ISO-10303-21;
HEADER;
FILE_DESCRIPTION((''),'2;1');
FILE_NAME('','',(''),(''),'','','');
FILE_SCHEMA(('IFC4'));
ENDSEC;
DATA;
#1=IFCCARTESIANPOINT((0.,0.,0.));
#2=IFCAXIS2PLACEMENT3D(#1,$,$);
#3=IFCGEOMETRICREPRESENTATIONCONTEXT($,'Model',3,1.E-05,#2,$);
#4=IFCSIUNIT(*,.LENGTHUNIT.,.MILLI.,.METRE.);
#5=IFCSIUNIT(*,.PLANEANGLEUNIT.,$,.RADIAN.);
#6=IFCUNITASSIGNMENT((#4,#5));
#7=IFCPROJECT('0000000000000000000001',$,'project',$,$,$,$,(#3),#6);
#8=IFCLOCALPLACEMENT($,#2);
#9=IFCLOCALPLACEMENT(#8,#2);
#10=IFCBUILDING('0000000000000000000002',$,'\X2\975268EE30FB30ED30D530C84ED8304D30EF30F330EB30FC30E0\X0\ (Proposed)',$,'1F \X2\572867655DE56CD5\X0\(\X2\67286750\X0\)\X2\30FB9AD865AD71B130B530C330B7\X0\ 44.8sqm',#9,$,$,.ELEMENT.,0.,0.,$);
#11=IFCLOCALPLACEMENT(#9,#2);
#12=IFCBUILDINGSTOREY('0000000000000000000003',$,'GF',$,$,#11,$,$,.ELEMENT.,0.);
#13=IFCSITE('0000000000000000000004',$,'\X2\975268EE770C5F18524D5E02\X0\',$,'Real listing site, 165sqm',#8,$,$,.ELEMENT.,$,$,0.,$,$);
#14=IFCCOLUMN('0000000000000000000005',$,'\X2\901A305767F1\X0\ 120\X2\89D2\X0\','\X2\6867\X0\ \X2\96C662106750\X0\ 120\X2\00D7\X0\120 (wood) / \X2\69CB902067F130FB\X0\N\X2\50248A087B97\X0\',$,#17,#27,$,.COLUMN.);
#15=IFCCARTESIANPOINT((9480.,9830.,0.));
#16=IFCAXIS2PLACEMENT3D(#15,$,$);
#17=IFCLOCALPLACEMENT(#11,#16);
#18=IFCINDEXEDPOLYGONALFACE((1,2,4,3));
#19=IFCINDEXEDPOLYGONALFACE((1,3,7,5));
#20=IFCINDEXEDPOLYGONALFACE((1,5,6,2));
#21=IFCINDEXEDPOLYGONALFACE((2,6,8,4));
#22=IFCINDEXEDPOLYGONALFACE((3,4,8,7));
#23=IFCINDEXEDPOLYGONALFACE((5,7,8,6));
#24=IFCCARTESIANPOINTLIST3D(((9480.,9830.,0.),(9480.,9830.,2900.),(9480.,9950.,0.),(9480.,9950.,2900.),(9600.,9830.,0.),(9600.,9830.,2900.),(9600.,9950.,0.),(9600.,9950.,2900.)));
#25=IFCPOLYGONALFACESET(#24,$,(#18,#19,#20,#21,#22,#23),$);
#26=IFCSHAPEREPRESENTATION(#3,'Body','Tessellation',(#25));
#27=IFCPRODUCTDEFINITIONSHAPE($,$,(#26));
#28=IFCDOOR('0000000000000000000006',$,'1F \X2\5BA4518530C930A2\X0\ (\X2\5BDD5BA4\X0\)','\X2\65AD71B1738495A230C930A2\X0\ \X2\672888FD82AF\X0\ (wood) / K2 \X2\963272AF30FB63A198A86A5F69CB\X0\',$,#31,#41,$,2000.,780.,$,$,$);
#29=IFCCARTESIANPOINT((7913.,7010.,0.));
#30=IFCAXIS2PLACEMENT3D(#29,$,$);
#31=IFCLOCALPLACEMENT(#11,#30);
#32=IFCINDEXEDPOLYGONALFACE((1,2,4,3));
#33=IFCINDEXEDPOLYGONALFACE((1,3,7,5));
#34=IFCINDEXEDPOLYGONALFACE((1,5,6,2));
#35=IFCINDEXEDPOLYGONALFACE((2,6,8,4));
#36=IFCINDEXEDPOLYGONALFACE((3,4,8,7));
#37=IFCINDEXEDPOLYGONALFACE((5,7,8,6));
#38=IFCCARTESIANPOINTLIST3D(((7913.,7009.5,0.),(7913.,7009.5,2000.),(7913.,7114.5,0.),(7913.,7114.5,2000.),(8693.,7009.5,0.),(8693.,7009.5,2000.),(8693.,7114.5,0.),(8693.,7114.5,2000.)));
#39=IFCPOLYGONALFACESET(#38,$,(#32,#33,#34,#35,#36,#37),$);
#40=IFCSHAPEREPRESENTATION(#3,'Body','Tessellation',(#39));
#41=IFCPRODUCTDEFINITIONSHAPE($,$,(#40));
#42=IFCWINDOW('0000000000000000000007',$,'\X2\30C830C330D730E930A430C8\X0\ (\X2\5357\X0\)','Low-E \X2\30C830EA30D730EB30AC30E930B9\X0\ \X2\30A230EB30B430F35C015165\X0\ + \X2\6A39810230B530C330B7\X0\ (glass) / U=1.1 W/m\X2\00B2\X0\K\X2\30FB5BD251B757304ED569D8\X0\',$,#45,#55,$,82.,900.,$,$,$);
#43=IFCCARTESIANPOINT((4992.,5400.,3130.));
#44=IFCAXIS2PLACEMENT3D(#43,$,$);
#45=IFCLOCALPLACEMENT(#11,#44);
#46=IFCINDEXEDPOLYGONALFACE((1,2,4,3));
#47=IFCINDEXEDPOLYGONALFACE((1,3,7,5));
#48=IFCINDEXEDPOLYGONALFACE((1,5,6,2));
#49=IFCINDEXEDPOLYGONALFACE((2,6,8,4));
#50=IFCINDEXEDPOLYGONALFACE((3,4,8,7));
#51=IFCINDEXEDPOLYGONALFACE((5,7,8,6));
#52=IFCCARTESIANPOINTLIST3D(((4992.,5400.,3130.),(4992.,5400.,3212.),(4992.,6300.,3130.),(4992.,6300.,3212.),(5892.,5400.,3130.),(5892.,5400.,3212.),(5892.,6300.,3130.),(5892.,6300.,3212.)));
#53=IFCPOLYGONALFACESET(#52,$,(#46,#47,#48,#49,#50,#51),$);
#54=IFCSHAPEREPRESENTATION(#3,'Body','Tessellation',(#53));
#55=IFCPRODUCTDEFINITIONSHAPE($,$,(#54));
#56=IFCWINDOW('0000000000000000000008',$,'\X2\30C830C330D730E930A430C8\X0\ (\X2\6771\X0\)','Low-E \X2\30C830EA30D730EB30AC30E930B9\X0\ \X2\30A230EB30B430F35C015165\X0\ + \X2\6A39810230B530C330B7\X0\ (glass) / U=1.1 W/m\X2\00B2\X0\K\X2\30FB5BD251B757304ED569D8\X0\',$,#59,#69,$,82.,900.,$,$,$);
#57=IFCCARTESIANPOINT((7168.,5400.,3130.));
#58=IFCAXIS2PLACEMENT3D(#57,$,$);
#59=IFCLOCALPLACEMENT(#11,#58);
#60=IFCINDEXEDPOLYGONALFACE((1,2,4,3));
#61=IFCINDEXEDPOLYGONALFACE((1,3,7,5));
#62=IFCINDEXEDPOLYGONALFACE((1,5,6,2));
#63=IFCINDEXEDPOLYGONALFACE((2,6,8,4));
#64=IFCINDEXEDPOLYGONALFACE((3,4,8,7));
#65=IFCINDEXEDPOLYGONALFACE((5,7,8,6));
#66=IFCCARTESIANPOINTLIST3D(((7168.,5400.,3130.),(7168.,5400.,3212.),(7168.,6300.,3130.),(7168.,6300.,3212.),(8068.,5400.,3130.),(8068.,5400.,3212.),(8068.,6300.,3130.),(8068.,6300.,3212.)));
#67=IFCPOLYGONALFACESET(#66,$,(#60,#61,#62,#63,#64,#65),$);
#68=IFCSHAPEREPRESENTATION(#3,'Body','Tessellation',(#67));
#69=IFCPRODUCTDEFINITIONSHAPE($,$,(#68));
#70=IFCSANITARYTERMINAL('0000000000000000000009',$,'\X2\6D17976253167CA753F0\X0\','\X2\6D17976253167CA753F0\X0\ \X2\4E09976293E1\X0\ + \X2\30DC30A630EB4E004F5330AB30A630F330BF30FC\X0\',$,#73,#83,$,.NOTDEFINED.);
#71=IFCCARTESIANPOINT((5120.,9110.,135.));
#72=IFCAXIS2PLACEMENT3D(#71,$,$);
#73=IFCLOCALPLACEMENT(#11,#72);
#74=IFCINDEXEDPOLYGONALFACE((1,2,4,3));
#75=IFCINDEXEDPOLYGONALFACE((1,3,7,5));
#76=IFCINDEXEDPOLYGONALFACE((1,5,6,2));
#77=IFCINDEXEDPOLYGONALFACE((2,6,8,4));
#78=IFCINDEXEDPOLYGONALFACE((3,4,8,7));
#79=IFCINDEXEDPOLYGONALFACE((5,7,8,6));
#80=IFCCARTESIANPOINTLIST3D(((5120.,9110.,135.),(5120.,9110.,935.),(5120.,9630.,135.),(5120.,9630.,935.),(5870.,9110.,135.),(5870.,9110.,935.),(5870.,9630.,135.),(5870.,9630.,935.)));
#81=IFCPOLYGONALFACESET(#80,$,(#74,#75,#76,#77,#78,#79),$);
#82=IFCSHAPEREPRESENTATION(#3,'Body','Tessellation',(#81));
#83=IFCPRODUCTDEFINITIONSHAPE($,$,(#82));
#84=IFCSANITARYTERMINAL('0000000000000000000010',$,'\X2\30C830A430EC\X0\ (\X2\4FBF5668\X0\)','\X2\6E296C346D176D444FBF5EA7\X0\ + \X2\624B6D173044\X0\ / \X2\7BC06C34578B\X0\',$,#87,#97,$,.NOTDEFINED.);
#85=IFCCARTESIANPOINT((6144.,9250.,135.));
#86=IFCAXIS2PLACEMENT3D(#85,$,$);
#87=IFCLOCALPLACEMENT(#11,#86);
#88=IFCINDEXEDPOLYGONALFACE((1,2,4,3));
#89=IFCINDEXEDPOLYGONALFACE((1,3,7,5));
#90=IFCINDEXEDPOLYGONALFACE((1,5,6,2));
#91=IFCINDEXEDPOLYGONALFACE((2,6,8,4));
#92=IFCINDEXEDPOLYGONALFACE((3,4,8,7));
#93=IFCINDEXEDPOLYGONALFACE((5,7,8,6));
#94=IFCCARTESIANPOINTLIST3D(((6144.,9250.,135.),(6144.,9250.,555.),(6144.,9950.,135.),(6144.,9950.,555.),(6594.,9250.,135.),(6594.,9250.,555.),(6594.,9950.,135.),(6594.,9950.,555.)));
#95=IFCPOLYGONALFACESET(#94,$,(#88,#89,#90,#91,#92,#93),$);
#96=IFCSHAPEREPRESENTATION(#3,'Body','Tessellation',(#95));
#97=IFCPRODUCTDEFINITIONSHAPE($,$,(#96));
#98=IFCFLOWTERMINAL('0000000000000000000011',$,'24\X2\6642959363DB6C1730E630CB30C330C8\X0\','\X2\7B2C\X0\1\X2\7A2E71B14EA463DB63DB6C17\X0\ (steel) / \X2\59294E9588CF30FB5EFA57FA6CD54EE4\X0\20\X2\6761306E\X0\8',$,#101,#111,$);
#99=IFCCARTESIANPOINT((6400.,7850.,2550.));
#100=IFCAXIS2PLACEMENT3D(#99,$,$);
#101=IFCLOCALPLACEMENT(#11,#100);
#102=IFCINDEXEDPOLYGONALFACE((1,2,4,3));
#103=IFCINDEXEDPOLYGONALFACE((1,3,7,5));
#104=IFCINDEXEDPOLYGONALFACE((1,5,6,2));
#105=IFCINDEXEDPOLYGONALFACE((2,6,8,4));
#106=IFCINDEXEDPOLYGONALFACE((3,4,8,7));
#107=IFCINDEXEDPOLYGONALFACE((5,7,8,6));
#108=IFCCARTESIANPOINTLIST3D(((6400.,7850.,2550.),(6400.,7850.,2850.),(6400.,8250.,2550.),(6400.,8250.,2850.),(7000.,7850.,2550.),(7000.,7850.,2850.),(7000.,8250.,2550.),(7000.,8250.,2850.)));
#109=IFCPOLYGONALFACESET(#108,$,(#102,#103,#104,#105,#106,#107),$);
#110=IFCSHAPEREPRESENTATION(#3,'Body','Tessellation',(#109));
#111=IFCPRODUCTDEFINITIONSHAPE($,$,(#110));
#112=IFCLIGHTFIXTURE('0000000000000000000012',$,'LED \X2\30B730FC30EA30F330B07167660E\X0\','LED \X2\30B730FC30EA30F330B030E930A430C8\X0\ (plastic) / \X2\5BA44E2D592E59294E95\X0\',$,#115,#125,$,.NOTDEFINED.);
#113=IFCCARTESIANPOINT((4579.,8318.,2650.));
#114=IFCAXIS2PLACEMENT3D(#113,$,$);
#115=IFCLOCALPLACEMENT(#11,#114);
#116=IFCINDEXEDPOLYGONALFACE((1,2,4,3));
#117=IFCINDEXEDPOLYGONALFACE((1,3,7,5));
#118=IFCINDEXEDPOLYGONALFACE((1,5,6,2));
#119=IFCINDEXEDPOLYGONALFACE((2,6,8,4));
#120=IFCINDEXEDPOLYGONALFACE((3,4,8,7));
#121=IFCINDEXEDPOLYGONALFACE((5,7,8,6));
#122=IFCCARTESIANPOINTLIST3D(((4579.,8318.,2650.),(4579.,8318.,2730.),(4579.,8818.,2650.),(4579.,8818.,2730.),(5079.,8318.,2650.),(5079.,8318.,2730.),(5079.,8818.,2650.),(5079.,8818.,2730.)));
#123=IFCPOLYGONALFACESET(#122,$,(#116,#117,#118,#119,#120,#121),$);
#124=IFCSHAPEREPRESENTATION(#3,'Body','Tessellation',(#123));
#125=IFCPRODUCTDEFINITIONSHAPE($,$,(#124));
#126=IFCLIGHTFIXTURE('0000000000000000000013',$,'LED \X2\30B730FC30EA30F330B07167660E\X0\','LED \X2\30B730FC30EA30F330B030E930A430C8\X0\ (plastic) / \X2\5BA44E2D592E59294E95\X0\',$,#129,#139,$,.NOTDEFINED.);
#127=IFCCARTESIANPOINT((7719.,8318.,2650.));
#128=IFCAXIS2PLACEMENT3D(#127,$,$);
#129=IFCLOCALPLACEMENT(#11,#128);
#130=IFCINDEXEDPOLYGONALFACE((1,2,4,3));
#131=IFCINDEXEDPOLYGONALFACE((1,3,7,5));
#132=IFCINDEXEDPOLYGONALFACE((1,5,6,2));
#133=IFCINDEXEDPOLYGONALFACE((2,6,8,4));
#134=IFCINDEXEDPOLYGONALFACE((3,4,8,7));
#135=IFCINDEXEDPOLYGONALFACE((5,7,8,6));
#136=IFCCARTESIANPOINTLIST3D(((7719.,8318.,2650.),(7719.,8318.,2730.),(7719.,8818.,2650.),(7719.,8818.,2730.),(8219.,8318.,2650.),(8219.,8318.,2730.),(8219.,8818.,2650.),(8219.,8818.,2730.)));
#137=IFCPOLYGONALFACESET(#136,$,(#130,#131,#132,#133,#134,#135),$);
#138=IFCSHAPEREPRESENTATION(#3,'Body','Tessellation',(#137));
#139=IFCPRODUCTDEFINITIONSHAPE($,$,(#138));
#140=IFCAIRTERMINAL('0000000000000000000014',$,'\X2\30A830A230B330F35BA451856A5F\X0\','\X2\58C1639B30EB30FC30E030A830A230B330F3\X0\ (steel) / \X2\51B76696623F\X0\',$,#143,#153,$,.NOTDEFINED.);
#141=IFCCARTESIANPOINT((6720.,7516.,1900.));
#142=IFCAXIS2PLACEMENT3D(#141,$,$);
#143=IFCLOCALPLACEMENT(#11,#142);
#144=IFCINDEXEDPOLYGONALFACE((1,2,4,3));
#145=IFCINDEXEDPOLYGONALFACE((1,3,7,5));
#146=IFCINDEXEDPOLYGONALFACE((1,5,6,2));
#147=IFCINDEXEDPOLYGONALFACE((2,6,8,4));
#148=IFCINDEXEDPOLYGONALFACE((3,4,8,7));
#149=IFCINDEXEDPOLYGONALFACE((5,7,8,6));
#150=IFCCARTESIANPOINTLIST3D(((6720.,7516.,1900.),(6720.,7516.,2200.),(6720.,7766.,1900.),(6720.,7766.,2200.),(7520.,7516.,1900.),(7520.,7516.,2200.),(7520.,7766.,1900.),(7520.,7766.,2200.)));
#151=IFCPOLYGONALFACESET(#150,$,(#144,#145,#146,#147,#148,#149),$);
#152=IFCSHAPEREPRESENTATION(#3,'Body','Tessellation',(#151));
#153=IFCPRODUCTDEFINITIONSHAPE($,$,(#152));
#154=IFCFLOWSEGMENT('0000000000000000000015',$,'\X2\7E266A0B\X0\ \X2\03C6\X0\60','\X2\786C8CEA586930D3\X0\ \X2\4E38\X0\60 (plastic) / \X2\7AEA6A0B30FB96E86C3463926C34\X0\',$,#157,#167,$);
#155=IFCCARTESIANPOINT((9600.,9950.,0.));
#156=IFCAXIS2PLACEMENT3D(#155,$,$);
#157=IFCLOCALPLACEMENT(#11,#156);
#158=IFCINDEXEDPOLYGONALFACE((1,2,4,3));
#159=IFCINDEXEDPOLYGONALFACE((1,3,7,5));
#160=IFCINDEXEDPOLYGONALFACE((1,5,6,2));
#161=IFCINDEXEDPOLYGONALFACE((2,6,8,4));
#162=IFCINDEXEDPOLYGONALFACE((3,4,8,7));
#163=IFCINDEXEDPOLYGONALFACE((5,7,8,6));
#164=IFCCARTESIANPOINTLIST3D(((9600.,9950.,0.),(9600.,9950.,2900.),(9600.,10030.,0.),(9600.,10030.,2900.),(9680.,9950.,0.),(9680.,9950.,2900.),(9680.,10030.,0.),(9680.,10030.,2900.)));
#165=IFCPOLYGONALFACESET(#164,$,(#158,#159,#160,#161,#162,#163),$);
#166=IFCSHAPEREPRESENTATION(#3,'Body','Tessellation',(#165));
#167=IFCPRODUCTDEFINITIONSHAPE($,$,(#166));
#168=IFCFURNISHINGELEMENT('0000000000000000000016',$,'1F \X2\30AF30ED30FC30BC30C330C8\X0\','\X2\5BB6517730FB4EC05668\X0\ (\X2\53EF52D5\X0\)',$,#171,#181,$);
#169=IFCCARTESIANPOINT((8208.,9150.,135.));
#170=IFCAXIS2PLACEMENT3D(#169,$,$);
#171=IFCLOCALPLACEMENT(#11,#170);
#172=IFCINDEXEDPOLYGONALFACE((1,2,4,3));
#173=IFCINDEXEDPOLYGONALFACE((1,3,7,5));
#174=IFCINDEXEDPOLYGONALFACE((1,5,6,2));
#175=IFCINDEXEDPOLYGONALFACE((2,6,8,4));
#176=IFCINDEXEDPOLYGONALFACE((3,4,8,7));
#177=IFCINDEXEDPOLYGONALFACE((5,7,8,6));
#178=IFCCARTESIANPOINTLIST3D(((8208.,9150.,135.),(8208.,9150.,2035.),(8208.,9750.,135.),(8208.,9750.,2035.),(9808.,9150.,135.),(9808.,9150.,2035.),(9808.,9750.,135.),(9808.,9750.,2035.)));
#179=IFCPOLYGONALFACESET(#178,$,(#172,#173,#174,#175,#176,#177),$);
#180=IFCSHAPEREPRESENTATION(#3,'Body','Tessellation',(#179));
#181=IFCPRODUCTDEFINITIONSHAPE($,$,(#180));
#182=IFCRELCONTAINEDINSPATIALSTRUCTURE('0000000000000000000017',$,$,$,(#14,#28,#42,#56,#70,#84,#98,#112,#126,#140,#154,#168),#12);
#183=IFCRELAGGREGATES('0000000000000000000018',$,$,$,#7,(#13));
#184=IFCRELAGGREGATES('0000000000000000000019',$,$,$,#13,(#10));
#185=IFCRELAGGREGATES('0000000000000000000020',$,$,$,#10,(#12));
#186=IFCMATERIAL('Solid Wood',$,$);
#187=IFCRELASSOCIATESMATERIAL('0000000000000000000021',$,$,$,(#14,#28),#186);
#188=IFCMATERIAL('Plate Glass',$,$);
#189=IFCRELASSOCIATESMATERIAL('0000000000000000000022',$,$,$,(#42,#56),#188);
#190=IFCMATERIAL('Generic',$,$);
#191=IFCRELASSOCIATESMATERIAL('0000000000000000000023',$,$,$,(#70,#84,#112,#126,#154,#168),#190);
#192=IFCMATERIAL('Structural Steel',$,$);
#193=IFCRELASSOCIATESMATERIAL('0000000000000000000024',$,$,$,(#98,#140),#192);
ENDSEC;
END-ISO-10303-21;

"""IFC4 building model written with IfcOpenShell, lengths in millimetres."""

from ifc_helpers import new_model, si_unit, frame, frame_2d, origin, place, context, project, spatial, rectangle, extrude, material, element, save


model = new_model("IFC4")

# Units and contexts
model_context = context("Model", 3, precision=1e-05, world=origin())
ifc_project = project(units=[si_unit("LENGTHUNIT", "METRE", prefix="MILLI"), si_unit("PLANEANGLEUNIT", "RADIAN")], contexts=[model_context])

# Site, building, storey
site_placement = place(None, origin())
site = spatial("IfcSite", under=ifc_project, at=site_placement, Name="青森県弘前市", ObjectType="Real listing site, 165sqm", CompositionType="ELEMENT", RefElevation=0.0)
building_placement = place(site_placement, origin())
building = spatial("IfcBuilding", under=site, at=building_placement, Name="青森・ロフト付きワンルーム (Proposed)", ObjectType="1F 在来工法(木材)・高断熱サッシ 44.8sqm", CompositionType="ELEMENT", ElevationOfRefHeight=0.0, ElevationOfTerrain=0.0)
storey_placement = place(building_placement, origin())
storey = spatial("IfcBuildingStorey", under=building, at=storey_placement, Name="GF", CompositionType="ELEMENT", Elevation=0.0)

# Column
ifc_material_1 = material(Name="Solid Wood")
column_1_placement = place(storey_placement, frame((9480.0, 9830.0, 0.0)))
element("IfcColumn", 1, at=column_1_placement, inside=storey, material=ifc_material_1, Name="通し柱 120角", Description="桧 集成材 120×120 (wood) / 構造柱・N値計算", PredefinedType="COLUMN", context=model_context, shape_type="SweptSolid", body=[
    extrude(rectangle(XDim=120.0, YDim=120.0, at=frame_2d((60.0, 60.0))), frame((9480.0, 9830.0, 0.0)), (0.0, 0.0, 1.0), 2900.0),
])

# Door
door_placement = place(storey_placement, frame((7913.0, 7010.0, 0.0)))
element("IfcDoor", 2, at=door_placement, inside=storey, material=ifc_material_1, Name="1F 室内ドア (寝室)", Description="断熱玄関ドア 木製芯 (wood) / K2 防犯・採風機構", OverallHeight=2000.0, OverallWidth=780.0, context=model_context, shape_type="SweptSolid", body=[
    extrude(rectangle(XDim=780.0, YDim=105.0, at=frame_2d((390.0, 52.0))), frame((7913.0, 7010.0, 0.0)), (0.0, 0.0, 1.0), 2000.0),
])

# Windows
ifc_material_2 = material(Name="Plate Glass")
window_1_placement = place(storey_placement, frame((4992.0, 5400.0, 3130.0)))
element("IfcWindow", 3, at=window_1_placement, inside=storey, material=ifc_material_2, Name="トップライト (南)", Description="Low-E トリプルガラス アルゴン封入 + 樹脂サッシ (glass) / U=1.1 W/m²K・寒冷地仕様", OverallHeight=82.0, OverallWidth=900.0, context=model_context, shape_type="SweptSolid", body=[
    extrude(rectangle(XDim=900.0, YDim=900.0, at=frame_2d((450.0, 450.0))), frame((4992.0, 5400.0, 3130.0)), (0.0, 0.0, 1.0), 82.0),
])
window_2_placement = place(storey_placement, frame((7168.0, 5400.0, 3130.0)))
element("IfcWindow", 4, at=window_2_placement, inside=storey, material=ifc_material_2, Name="トップライト (東)", Description="Low-E トリプルガラス アルゴン封入 + 樹脂サッシ (glass) / U=1.1 W/m²K・寒冷地仕様", OverallHeight=82.0, OverallWidth=900.0, context=model_context, shape_type="SweptSolid", body=[
    extrude(rectangle(XDim=900.0, YDim=900.0, at=frame_2d((450.0, 450.0))), frame((7168.0, 5400.0, 3130.0)), (0.0, 0.0, 1.0), 82.0),
])

# Sanitary terminals
ifc_material_3 = material(Name="Generic")
sanitary_terminal_1_placement = place(storey_placement, frame((5120.0, 9110.0, 135.0)))
element("IfcSanitaryTerminal", 5, at=sanitary_terminal_1_placement, inside=storey, material=ifc_material_3, Name="洗面化粧台", Description="洗面化粧台 三面鏡 + ボウル一体カウンター", PredefinedType="NOTDEFINED", context=model_context, shape_type="SweptSolid", body=[
    extrude(rectangle(XDim=750.0, YDim=520.0, at=frame_2d((375.0, 260.0))), frame((5120.0, 9110.0, 135.0)), (0.0, 0.0, 1.0), 800.0),
])
sanitary_terminal_2_placement = place(storey_placement, frame((6144.0, 9250.0, 135.0)))
element("IfcSanitaryTerminal", 6, at=sanitary_terminal_2_placement, inside=storey, material=ifc_material_3, Name="トイレ (便器)", Description="温水洗浄便座 + 手洗い / 節水型", PredefinedType="NOTDEFINED", context=model_context, shape_type="SweptSolid", body=[
    extrude(rectangle(XDim=450.0, YDim=700.0, at=frame_2d((225.0, 350.0))), frame((6144.0, 9250.0, 135.0)), (0.0, 0.0, 1.0), 420.0),
])

# Flow terminal
ifc_material_4 = material(Name="Structural Steel")
flow_terminal_placement = place(storey_placement, frame((6400.0, 7850.0, 2550.0)))
element("IfcFlowTerminal", 7, at=flow_terminal_placement, inside=storey, material=ifc_material_4, Name="24時間換気ユニット", Description="第1種熱交換換気 (steel) / 天井裏・建基法令20条の8", context=model_context, shape_type="SweptSolid", body=[
    extrude(rectangle(XDim=600.0, YDim=400.0, at=frame_2d((300.0, 200.0))), frame((6400.0, 7850.0, 2550.0)), (0.0, 0.0, 1.0), 300.0),
])

# Light fixtures
light_fixture_1_placement = place(storey_placement, frame((4579.0, 8318.0, 2650.0)))
element("IfcLightFixture", 8, at=light_fixture_1_placement, inside=storey, material=ifc_material_3, Name="LED シーリング照明", Description="LED シーリングライト (plastic) / 室中央天井", PredefinedType="NOTDEFINED", context=model_context, shape_type="SweptSolid", body=[
    extrude(rectangle(XDim=500.0, YDim=500.0, at=frame_2d((250.0, 250.0))), frame((4579.0, 8318.0, 2650.0)), (0.0, 0.0, 1.0), 80.0),
])
light_fixture_2_placement = place(storey_placement, frame((7719.0, 8318.0, 2650.0)))
element("IfcLightFixture", 9, at=light_fixture_2_placement, inside=storey, material=ifc_material_3, Name="LED シーリング照明", Description="LED シーリングライト (plastic) / 室中央天井", PredefinedType="NOTDEFINED", context=model_context, shape_type="SweptSolid", body=[
    extrude(rectangle(XDim=500.0, YDim=500.0, at=frame_2d((250.0, 250.0))), frame((7719.0, 8318.0, 2650.0)), (0.0, 0.0, 1.0), 80.0),
])

# Air terminal
air_terminal_placement = place(storey_placement, frame((6720.0, 7516.0, 1900.0)))
element("IfcAirTerminal", 10, at=air_terminal_placement, inside=storey, material=ifc_material_4, Name="エアコン室内機", Description="壁掛ルームエアコン (steel) / 冷暖房", PredefinedType="NOTDEFINED", context=model_context, shape_type="SweptSolid", body=[
    extrude(rectangle(XDim=800.0, YDim=250.0, at=frame_2d((400.0, 125.0))), frame((6720.0, 7516.0, 1900.0)), (0.0, 0.0, 1.0), 300.0),
])

# Flow segment
flow_segment_placement = place(storey_placement, frame((9600.0, 9950.0, 0.0)))
element("IfcFlowSegment", 11, at=flow_segment_placement, inside=storey, material=ifc_material_3, Name="縦樋 φ60", Description="硬質塩ビ 丸60 (plastic) / 竪樋・雨水排水", context=model_context, shape_type="SweptSolid", body=[
    extrude(rectangle(XDim=80.0, YDim=80.0, at=frame_2d((40.0, 40.0))), frame((9600.0, 9950.0, 0.0)), (0.0, 0.0, 1.0), 2900.0),
])

# Furnishing element
furnishing_placement = place(storey_placement, frame((8208.0, 9150.0, 135.0)))
element("IfcFurnishingElement", 12, at=furnishing_placement, inside=storey, material=ifc_material_3, Name="1F クローゼット", Description="家具・什器 (可動)", context=model_context, shape_type="SweptSolid", body=[
    extrude(rectangle(XDim=1600.0, YDim=600.0, at=frame_2d((800.0, 300.0))), frame((8208.0, 9150.0, 135.0)), (0.0, 0.0, 1.0), 1900.0),
])

save(model, "model.ifc")
